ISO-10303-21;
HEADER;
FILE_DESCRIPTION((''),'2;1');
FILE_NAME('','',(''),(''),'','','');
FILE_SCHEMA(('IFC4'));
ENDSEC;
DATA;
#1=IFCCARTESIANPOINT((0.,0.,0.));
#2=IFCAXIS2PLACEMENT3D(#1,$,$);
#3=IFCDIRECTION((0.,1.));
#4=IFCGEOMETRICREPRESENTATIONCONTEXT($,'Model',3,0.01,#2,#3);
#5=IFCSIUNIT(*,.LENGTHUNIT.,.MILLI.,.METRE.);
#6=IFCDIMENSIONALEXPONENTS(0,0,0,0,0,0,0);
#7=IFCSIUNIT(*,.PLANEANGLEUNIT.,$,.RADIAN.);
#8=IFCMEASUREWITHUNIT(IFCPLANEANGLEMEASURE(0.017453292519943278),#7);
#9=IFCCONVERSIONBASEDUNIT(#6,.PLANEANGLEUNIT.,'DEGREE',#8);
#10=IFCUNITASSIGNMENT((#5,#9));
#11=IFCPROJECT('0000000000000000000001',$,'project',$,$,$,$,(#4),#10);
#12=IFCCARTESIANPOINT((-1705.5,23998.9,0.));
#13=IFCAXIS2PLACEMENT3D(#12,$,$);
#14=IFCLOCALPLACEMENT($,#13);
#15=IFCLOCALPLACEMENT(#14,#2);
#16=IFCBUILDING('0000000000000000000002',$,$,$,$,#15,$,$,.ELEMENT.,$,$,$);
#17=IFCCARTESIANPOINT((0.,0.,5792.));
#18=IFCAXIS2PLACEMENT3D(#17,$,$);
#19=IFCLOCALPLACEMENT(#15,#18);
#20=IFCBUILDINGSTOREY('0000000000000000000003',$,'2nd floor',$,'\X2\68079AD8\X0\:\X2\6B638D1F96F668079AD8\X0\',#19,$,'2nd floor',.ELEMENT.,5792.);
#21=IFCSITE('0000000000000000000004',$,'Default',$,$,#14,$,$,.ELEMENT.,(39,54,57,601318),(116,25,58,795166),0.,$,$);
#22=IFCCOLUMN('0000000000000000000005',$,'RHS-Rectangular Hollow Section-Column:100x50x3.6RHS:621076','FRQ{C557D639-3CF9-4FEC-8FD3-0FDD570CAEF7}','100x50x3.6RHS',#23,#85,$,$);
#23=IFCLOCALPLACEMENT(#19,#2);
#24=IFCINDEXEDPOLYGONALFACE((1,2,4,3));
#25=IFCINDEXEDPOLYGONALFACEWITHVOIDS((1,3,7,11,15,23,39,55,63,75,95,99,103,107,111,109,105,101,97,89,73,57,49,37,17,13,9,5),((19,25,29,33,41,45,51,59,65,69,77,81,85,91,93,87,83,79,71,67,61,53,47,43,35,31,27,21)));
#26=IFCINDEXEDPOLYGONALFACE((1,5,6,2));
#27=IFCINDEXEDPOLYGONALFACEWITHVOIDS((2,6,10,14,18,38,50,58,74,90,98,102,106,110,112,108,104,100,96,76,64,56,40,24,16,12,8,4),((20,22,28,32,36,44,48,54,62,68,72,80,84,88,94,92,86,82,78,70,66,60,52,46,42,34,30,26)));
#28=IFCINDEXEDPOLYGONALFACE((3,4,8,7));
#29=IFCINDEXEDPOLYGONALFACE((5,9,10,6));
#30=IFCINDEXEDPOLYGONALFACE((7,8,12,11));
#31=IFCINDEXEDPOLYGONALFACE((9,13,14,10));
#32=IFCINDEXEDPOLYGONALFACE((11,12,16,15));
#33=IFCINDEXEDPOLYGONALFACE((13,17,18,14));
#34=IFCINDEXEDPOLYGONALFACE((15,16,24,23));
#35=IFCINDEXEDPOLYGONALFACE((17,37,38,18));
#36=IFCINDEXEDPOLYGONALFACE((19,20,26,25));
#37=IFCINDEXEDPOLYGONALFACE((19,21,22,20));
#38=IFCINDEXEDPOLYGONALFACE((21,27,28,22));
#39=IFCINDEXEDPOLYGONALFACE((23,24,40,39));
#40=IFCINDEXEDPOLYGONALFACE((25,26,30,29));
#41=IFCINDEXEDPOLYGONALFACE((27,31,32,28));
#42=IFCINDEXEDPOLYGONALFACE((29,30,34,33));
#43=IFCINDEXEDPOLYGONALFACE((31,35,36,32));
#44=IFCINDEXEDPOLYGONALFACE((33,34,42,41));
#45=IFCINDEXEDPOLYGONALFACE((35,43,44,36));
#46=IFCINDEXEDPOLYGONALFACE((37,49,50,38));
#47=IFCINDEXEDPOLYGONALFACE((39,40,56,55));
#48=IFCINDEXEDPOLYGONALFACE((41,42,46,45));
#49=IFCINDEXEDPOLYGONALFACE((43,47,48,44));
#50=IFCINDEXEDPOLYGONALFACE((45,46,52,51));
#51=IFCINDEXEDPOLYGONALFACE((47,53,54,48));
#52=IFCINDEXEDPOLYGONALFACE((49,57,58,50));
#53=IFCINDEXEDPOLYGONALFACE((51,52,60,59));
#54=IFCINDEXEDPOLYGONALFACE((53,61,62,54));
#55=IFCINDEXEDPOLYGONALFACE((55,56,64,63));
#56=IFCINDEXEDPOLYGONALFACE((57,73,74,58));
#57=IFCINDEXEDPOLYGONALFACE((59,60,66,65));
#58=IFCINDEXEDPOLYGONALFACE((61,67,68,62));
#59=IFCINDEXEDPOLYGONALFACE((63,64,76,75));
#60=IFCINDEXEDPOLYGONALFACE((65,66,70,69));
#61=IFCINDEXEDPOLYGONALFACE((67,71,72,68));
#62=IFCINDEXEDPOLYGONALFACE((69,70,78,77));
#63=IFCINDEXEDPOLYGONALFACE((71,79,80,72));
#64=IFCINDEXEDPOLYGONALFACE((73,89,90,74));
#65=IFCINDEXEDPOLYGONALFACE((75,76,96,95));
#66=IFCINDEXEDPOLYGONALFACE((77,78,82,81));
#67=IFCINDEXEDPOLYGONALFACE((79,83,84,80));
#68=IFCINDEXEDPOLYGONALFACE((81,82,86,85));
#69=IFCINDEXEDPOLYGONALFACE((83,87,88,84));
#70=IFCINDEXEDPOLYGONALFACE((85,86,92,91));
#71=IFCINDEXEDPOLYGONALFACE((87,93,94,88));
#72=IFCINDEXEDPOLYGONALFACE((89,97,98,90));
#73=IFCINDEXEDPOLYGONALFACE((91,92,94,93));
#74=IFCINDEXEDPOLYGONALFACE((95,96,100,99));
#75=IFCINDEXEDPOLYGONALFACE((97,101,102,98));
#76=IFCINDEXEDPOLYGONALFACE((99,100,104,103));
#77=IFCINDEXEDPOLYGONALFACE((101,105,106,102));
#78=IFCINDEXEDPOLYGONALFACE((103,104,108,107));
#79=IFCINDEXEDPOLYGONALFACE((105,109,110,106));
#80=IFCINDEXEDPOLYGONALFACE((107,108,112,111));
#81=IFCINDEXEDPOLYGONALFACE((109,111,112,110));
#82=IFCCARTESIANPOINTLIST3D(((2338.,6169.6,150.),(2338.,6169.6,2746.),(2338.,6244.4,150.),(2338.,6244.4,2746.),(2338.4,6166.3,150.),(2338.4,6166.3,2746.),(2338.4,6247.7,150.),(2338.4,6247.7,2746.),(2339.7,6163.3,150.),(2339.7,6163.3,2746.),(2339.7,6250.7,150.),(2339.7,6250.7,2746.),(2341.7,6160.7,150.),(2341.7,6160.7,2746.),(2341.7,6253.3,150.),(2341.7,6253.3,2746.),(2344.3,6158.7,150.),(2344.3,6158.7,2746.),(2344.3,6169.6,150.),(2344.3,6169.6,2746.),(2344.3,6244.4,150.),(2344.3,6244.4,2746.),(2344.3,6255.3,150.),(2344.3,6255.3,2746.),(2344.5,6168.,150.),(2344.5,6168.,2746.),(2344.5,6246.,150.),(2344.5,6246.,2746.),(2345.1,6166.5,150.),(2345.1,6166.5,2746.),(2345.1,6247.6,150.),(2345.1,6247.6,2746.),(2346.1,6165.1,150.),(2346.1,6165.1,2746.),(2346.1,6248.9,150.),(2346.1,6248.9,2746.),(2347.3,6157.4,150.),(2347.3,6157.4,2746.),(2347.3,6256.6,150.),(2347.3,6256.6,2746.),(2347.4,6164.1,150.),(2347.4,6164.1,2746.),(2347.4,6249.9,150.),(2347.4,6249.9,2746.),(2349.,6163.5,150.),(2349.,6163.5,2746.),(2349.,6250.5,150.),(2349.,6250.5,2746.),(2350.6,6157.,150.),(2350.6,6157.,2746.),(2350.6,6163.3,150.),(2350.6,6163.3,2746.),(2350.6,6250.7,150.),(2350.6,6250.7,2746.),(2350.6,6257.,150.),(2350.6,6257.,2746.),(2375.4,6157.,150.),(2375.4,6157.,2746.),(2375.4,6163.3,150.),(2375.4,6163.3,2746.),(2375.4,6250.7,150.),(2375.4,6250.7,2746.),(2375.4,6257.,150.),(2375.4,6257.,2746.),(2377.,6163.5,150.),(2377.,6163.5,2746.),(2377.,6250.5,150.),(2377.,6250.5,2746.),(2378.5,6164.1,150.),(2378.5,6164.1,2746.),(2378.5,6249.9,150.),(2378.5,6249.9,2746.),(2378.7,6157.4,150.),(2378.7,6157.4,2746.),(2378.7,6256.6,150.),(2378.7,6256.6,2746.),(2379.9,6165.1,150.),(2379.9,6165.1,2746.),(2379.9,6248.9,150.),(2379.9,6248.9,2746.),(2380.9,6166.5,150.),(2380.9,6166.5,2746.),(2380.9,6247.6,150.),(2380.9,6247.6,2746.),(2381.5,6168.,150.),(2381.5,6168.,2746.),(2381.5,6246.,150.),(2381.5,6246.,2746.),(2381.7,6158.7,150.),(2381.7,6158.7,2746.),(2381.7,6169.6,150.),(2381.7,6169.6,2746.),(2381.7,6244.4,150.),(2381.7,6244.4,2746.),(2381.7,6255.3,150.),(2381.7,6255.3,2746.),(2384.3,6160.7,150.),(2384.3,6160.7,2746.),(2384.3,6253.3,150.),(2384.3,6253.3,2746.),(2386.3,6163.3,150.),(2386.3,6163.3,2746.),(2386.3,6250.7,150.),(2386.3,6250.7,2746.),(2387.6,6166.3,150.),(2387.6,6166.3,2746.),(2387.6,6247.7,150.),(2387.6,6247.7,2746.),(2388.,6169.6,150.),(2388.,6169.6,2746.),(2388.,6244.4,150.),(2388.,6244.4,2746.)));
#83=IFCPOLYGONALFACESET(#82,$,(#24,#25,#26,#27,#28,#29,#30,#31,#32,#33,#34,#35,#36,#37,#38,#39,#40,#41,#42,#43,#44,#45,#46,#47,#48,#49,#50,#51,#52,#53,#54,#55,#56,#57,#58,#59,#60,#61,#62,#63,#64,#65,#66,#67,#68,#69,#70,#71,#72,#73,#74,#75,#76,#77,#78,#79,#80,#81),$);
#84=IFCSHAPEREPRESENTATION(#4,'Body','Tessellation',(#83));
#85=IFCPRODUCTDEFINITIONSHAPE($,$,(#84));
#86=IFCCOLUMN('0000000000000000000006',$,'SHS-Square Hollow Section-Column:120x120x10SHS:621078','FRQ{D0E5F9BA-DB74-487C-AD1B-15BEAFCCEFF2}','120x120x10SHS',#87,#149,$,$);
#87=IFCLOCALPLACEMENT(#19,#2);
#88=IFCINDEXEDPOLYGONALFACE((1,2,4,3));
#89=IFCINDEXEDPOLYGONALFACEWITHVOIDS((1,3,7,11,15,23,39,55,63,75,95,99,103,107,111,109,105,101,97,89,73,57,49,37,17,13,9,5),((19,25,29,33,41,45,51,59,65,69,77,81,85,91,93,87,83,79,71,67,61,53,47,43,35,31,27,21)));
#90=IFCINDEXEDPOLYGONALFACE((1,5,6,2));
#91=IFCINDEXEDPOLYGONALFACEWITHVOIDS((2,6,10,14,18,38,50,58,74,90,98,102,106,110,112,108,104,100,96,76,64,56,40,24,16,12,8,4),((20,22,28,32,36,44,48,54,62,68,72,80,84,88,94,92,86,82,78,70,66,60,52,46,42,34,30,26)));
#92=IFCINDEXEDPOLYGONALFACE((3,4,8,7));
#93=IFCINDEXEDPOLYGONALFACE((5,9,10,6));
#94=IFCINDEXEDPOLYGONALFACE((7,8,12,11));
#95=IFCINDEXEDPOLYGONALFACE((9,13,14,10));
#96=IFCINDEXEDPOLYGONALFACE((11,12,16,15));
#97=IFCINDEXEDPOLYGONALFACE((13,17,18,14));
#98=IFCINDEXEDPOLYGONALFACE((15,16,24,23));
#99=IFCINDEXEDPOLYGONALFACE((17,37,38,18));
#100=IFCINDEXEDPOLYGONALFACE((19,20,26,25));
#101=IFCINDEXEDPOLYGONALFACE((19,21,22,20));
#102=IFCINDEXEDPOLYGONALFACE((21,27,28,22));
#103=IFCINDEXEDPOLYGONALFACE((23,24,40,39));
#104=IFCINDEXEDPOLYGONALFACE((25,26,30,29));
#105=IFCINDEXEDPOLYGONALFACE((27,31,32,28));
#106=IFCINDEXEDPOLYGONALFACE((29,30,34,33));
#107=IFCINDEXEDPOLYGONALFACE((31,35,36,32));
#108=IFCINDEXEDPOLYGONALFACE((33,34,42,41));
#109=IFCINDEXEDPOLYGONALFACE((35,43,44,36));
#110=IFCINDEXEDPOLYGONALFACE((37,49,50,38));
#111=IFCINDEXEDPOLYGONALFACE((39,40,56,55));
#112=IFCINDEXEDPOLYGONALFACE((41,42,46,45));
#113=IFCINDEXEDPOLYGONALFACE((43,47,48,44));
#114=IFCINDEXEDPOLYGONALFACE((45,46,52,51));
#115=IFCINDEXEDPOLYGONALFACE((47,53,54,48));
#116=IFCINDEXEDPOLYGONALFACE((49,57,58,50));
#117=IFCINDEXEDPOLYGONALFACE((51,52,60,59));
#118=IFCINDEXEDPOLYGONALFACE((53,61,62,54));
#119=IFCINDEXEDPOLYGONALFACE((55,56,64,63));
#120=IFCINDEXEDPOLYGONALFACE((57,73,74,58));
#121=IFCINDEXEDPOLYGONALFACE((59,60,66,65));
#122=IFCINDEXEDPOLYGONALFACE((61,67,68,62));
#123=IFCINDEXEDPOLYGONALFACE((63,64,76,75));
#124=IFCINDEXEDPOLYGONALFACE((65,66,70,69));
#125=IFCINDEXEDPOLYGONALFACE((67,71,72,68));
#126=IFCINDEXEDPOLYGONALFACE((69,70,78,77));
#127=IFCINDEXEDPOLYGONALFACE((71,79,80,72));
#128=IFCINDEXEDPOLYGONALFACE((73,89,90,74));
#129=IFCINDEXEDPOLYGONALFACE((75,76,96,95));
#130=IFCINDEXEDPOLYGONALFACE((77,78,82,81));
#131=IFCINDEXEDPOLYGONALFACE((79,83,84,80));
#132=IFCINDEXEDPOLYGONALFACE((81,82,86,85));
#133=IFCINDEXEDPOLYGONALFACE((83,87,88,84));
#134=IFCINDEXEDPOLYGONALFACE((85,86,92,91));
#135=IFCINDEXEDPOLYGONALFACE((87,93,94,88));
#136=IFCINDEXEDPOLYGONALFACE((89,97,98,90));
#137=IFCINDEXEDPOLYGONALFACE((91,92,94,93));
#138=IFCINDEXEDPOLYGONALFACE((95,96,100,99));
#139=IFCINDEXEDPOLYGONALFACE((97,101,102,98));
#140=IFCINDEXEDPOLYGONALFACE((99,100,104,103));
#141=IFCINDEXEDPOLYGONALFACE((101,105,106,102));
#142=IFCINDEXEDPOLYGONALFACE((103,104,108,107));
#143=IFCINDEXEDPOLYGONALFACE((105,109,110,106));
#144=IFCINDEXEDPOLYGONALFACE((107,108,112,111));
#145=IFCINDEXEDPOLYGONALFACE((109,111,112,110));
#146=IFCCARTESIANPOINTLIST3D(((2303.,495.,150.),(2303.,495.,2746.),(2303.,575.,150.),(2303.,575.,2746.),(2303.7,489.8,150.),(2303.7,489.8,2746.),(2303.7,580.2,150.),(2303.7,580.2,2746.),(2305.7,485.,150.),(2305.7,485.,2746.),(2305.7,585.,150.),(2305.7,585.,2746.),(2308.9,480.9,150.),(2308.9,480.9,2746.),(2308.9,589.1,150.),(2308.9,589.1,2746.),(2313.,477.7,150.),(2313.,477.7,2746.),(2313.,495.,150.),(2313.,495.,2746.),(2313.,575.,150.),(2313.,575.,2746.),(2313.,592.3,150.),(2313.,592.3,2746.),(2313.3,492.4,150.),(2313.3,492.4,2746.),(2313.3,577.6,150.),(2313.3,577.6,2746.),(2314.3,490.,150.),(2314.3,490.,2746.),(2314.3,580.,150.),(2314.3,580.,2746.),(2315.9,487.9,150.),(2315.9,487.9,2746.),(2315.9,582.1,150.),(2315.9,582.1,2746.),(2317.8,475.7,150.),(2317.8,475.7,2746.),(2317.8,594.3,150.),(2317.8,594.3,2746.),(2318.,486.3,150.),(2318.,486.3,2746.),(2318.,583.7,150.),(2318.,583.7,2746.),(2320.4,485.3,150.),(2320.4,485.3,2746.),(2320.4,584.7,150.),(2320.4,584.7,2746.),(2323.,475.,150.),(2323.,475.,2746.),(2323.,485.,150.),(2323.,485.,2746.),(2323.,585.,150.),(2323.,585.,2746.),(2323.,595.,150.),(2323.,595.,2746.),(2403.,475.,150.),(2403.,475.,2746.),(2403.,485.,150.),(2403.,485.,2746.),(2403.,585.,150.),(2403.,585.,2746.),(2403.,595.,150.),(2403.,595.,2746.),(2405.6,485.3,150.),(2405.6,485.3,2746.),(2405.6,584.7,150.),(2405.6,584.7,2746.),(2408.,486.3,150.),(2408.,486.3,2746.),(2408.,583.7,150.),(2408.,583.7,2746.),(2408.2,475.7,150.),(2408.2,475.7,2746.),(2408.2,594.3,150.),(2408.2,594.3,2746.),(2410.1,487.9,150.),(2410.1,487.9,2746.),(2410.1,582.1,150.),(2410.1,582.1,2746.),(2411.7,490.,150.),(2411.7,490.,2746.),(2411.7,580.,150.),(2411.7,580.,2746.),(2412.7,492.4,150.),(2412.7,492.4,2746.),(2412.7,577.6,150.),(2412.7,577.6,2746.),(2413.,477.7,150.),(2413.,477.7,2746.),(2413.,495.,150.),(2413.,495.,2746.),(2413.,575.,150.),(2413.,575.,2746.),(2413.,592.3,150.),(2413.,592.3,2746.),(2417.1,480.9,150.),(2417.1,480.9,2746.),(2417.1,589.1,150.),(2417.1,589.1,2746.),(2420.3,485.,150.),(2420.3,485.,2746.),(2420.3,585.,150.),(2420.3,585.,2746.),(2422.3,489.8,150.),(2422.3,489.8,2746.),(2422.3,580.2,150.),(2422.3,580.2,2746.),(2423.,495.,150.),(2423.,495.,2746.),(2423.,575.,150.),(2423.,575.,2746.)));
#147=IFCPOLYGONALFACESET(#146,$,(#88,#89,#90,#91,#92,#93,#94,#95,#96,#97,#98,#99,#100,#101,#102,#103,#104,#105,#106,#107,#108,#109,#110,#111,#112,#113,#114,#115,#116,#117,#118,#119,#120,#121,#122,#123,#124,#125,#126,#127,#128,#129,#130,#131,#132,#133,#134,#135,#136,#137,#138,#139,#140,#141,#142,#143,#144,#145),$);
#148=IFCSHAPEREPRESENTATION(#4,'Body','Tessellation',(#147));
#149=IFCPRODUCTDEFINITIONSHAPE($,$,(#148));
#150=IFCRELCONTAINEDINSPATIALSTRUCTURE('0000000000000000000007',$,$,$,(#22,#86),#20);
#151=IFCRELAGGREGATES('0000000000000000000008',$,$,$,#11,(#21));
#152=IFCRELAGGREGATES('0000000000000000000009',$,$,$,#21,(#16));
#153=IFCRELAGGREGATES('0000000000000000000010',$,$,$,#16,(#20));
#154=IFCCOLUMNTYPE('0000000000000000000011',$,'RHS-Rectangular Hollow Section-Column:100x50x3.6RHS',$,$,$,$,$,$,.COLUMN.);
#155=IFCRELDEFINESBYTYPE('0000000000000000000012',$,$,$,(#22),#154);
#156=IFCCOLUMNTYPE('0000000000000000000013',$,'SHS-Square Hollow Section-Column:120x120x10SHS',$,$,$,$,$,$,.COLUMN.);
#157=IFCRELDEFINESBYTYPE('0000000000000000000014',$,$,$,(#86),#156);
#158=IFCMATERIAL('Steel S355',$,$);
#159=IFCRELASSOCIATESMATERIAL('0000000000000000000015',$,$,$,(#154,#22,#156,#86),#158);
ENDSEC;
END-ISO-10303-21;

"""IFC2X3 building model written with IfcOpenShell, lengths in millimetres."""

from ifc_helpers import new_model, entity, si_unit, converted_unit, direction, frame, origin, origin_2d, place, context, project, spatial, hollow_rectangle, extrude, clip, halfspace, material, type_object, element, save


model = new_model("IFC2X3")

# Units and contexts
model_context = context("Model", 3, precision=0.01, world=origin(), true_north=direction((0.0, 1.0)))
ifc_project = project(units=[si_unit("LENGTHUNIT", "METRE", prefix="MILLI"), converted_unit("PLANEANGLEUNIT", "DEGREE", entity("IfcPlaneAngleMeasure", 0.017453292519943278), si_unit("PLANEANGLEUNIT", "RADIAN"), dimensions=[0, 0, 0, 0, 0, 0, 0])], contexts=[model_context])

# Site, building, storey
site_placement = place(None, frame((-1705.5, 23998.9, 0.0)))
site = spatial("IfcSite", under=ifc_project, at=site_placement, Name="Default", CompositionType="ELEMENT", RefLatitude=(39, 54, 57, 601318), RefLongitude=(116, 25, 58, 795166), RefElevation=0.0)
building_placement = place(site_placement, origin())
building = spatial("IfcBuilding", under=site, at=building_placement, CompositionType="ELEMENT")
storey_placement = place(building_placement, frame((0.0, 0.0, 5792.0)))
storey = spatial("IfcBuildingStorey", under=building, at=storey_placement, Name="2nd floor", ObjectType="标高:正负零标高", LongName="2nd floor", CompositionType="ELEMENT", Elevation=5792.0)

# Columns
ifc_material_1 = material(Name="Steel S355")
column_type_1 = type_object("IfcColumnType", Name="RHS-Rectangular Hollow Section-Column:100x50x3.6RHS", PredefinedType="COLUMN", material=ifc_material_1)
column_1_placement = place(storey_placement, frame((2363.0, 6207.0, 2746.0), z_axis=(0.0, 0.0, 1.0), x_axis=(-1.0, 0.0, 0.0)))
element("IfcColumn", 1, at=column_1_placement, inside=storey, type_object=column_type_1, material=ifc_material_1, Name="RHS-Rectangular Hollow Section-Column:100x50x3.6RHS:621076", Description="FRQ{C557D639-3CF9-4FEC-8FD3-0FDD570CAEF7}", ObjectType="100x50x3.6RHS", context=model_context, shape_type="Clipping", body=[
    clip(extrude(hollow_rectangle(XDim=50.0, YDim=100.0, WallThickness=6.3, InnerFilletRadius=6.3, OuterFilletRadius=12.6, at=origin_2d()), origin(), (0.0, 0.0, -1.0), 2651.9), halfspace(frame((2363.0, 6207.0, -2596.0), z_axis=(0.0, 0.0, 1.0), x_axis=(-1.0, 0.0, 0.0)), True)),
])
column_type_2 = type_object("IfcColumnType", Name="SHS-Square Hollow Section-Column:120x120x10SHS", PredefinedType="COLUMN", material=ifc_material_1)
column_2_placement = place(storey_placement, frame((2363.0, 535.0, 2746.0), z_axis=(0.0, 0.0, 1.0), x_axis=(0.0, -1.0, 0.0)))
element("IfcColumn", 2, at=column_2_placement, inside=storey, type_object=column_type_2, material=ifc_material_1, Name="SHS-Square Hollow Section-Column:120x120x10SHS:621078", Description="FRQ{D0E5F9BA-DB74-487C-AD1B-15BEAFCCEFF2}", ObjectType="120x120x10SHS", context=model_context, shape_type="Clipping", body=[
    clip(extrude(hollow_rectangle(XDim=120.0, YDim=120.0, WallThickness=10.0, InnerFilletRadius=10.0, OuterFilletRadius=20.0, at=origin_2d()), origin(), (0.0, 0.0, -1.0), 2680.9), halfspace(frame((535.0, -2363.0, -2596.0), z_axis=(0.0, 0.0, 1.0), x_axis=(0.0, 1.0, 0.0)), True)),
])

save(model, "model.ifc")
